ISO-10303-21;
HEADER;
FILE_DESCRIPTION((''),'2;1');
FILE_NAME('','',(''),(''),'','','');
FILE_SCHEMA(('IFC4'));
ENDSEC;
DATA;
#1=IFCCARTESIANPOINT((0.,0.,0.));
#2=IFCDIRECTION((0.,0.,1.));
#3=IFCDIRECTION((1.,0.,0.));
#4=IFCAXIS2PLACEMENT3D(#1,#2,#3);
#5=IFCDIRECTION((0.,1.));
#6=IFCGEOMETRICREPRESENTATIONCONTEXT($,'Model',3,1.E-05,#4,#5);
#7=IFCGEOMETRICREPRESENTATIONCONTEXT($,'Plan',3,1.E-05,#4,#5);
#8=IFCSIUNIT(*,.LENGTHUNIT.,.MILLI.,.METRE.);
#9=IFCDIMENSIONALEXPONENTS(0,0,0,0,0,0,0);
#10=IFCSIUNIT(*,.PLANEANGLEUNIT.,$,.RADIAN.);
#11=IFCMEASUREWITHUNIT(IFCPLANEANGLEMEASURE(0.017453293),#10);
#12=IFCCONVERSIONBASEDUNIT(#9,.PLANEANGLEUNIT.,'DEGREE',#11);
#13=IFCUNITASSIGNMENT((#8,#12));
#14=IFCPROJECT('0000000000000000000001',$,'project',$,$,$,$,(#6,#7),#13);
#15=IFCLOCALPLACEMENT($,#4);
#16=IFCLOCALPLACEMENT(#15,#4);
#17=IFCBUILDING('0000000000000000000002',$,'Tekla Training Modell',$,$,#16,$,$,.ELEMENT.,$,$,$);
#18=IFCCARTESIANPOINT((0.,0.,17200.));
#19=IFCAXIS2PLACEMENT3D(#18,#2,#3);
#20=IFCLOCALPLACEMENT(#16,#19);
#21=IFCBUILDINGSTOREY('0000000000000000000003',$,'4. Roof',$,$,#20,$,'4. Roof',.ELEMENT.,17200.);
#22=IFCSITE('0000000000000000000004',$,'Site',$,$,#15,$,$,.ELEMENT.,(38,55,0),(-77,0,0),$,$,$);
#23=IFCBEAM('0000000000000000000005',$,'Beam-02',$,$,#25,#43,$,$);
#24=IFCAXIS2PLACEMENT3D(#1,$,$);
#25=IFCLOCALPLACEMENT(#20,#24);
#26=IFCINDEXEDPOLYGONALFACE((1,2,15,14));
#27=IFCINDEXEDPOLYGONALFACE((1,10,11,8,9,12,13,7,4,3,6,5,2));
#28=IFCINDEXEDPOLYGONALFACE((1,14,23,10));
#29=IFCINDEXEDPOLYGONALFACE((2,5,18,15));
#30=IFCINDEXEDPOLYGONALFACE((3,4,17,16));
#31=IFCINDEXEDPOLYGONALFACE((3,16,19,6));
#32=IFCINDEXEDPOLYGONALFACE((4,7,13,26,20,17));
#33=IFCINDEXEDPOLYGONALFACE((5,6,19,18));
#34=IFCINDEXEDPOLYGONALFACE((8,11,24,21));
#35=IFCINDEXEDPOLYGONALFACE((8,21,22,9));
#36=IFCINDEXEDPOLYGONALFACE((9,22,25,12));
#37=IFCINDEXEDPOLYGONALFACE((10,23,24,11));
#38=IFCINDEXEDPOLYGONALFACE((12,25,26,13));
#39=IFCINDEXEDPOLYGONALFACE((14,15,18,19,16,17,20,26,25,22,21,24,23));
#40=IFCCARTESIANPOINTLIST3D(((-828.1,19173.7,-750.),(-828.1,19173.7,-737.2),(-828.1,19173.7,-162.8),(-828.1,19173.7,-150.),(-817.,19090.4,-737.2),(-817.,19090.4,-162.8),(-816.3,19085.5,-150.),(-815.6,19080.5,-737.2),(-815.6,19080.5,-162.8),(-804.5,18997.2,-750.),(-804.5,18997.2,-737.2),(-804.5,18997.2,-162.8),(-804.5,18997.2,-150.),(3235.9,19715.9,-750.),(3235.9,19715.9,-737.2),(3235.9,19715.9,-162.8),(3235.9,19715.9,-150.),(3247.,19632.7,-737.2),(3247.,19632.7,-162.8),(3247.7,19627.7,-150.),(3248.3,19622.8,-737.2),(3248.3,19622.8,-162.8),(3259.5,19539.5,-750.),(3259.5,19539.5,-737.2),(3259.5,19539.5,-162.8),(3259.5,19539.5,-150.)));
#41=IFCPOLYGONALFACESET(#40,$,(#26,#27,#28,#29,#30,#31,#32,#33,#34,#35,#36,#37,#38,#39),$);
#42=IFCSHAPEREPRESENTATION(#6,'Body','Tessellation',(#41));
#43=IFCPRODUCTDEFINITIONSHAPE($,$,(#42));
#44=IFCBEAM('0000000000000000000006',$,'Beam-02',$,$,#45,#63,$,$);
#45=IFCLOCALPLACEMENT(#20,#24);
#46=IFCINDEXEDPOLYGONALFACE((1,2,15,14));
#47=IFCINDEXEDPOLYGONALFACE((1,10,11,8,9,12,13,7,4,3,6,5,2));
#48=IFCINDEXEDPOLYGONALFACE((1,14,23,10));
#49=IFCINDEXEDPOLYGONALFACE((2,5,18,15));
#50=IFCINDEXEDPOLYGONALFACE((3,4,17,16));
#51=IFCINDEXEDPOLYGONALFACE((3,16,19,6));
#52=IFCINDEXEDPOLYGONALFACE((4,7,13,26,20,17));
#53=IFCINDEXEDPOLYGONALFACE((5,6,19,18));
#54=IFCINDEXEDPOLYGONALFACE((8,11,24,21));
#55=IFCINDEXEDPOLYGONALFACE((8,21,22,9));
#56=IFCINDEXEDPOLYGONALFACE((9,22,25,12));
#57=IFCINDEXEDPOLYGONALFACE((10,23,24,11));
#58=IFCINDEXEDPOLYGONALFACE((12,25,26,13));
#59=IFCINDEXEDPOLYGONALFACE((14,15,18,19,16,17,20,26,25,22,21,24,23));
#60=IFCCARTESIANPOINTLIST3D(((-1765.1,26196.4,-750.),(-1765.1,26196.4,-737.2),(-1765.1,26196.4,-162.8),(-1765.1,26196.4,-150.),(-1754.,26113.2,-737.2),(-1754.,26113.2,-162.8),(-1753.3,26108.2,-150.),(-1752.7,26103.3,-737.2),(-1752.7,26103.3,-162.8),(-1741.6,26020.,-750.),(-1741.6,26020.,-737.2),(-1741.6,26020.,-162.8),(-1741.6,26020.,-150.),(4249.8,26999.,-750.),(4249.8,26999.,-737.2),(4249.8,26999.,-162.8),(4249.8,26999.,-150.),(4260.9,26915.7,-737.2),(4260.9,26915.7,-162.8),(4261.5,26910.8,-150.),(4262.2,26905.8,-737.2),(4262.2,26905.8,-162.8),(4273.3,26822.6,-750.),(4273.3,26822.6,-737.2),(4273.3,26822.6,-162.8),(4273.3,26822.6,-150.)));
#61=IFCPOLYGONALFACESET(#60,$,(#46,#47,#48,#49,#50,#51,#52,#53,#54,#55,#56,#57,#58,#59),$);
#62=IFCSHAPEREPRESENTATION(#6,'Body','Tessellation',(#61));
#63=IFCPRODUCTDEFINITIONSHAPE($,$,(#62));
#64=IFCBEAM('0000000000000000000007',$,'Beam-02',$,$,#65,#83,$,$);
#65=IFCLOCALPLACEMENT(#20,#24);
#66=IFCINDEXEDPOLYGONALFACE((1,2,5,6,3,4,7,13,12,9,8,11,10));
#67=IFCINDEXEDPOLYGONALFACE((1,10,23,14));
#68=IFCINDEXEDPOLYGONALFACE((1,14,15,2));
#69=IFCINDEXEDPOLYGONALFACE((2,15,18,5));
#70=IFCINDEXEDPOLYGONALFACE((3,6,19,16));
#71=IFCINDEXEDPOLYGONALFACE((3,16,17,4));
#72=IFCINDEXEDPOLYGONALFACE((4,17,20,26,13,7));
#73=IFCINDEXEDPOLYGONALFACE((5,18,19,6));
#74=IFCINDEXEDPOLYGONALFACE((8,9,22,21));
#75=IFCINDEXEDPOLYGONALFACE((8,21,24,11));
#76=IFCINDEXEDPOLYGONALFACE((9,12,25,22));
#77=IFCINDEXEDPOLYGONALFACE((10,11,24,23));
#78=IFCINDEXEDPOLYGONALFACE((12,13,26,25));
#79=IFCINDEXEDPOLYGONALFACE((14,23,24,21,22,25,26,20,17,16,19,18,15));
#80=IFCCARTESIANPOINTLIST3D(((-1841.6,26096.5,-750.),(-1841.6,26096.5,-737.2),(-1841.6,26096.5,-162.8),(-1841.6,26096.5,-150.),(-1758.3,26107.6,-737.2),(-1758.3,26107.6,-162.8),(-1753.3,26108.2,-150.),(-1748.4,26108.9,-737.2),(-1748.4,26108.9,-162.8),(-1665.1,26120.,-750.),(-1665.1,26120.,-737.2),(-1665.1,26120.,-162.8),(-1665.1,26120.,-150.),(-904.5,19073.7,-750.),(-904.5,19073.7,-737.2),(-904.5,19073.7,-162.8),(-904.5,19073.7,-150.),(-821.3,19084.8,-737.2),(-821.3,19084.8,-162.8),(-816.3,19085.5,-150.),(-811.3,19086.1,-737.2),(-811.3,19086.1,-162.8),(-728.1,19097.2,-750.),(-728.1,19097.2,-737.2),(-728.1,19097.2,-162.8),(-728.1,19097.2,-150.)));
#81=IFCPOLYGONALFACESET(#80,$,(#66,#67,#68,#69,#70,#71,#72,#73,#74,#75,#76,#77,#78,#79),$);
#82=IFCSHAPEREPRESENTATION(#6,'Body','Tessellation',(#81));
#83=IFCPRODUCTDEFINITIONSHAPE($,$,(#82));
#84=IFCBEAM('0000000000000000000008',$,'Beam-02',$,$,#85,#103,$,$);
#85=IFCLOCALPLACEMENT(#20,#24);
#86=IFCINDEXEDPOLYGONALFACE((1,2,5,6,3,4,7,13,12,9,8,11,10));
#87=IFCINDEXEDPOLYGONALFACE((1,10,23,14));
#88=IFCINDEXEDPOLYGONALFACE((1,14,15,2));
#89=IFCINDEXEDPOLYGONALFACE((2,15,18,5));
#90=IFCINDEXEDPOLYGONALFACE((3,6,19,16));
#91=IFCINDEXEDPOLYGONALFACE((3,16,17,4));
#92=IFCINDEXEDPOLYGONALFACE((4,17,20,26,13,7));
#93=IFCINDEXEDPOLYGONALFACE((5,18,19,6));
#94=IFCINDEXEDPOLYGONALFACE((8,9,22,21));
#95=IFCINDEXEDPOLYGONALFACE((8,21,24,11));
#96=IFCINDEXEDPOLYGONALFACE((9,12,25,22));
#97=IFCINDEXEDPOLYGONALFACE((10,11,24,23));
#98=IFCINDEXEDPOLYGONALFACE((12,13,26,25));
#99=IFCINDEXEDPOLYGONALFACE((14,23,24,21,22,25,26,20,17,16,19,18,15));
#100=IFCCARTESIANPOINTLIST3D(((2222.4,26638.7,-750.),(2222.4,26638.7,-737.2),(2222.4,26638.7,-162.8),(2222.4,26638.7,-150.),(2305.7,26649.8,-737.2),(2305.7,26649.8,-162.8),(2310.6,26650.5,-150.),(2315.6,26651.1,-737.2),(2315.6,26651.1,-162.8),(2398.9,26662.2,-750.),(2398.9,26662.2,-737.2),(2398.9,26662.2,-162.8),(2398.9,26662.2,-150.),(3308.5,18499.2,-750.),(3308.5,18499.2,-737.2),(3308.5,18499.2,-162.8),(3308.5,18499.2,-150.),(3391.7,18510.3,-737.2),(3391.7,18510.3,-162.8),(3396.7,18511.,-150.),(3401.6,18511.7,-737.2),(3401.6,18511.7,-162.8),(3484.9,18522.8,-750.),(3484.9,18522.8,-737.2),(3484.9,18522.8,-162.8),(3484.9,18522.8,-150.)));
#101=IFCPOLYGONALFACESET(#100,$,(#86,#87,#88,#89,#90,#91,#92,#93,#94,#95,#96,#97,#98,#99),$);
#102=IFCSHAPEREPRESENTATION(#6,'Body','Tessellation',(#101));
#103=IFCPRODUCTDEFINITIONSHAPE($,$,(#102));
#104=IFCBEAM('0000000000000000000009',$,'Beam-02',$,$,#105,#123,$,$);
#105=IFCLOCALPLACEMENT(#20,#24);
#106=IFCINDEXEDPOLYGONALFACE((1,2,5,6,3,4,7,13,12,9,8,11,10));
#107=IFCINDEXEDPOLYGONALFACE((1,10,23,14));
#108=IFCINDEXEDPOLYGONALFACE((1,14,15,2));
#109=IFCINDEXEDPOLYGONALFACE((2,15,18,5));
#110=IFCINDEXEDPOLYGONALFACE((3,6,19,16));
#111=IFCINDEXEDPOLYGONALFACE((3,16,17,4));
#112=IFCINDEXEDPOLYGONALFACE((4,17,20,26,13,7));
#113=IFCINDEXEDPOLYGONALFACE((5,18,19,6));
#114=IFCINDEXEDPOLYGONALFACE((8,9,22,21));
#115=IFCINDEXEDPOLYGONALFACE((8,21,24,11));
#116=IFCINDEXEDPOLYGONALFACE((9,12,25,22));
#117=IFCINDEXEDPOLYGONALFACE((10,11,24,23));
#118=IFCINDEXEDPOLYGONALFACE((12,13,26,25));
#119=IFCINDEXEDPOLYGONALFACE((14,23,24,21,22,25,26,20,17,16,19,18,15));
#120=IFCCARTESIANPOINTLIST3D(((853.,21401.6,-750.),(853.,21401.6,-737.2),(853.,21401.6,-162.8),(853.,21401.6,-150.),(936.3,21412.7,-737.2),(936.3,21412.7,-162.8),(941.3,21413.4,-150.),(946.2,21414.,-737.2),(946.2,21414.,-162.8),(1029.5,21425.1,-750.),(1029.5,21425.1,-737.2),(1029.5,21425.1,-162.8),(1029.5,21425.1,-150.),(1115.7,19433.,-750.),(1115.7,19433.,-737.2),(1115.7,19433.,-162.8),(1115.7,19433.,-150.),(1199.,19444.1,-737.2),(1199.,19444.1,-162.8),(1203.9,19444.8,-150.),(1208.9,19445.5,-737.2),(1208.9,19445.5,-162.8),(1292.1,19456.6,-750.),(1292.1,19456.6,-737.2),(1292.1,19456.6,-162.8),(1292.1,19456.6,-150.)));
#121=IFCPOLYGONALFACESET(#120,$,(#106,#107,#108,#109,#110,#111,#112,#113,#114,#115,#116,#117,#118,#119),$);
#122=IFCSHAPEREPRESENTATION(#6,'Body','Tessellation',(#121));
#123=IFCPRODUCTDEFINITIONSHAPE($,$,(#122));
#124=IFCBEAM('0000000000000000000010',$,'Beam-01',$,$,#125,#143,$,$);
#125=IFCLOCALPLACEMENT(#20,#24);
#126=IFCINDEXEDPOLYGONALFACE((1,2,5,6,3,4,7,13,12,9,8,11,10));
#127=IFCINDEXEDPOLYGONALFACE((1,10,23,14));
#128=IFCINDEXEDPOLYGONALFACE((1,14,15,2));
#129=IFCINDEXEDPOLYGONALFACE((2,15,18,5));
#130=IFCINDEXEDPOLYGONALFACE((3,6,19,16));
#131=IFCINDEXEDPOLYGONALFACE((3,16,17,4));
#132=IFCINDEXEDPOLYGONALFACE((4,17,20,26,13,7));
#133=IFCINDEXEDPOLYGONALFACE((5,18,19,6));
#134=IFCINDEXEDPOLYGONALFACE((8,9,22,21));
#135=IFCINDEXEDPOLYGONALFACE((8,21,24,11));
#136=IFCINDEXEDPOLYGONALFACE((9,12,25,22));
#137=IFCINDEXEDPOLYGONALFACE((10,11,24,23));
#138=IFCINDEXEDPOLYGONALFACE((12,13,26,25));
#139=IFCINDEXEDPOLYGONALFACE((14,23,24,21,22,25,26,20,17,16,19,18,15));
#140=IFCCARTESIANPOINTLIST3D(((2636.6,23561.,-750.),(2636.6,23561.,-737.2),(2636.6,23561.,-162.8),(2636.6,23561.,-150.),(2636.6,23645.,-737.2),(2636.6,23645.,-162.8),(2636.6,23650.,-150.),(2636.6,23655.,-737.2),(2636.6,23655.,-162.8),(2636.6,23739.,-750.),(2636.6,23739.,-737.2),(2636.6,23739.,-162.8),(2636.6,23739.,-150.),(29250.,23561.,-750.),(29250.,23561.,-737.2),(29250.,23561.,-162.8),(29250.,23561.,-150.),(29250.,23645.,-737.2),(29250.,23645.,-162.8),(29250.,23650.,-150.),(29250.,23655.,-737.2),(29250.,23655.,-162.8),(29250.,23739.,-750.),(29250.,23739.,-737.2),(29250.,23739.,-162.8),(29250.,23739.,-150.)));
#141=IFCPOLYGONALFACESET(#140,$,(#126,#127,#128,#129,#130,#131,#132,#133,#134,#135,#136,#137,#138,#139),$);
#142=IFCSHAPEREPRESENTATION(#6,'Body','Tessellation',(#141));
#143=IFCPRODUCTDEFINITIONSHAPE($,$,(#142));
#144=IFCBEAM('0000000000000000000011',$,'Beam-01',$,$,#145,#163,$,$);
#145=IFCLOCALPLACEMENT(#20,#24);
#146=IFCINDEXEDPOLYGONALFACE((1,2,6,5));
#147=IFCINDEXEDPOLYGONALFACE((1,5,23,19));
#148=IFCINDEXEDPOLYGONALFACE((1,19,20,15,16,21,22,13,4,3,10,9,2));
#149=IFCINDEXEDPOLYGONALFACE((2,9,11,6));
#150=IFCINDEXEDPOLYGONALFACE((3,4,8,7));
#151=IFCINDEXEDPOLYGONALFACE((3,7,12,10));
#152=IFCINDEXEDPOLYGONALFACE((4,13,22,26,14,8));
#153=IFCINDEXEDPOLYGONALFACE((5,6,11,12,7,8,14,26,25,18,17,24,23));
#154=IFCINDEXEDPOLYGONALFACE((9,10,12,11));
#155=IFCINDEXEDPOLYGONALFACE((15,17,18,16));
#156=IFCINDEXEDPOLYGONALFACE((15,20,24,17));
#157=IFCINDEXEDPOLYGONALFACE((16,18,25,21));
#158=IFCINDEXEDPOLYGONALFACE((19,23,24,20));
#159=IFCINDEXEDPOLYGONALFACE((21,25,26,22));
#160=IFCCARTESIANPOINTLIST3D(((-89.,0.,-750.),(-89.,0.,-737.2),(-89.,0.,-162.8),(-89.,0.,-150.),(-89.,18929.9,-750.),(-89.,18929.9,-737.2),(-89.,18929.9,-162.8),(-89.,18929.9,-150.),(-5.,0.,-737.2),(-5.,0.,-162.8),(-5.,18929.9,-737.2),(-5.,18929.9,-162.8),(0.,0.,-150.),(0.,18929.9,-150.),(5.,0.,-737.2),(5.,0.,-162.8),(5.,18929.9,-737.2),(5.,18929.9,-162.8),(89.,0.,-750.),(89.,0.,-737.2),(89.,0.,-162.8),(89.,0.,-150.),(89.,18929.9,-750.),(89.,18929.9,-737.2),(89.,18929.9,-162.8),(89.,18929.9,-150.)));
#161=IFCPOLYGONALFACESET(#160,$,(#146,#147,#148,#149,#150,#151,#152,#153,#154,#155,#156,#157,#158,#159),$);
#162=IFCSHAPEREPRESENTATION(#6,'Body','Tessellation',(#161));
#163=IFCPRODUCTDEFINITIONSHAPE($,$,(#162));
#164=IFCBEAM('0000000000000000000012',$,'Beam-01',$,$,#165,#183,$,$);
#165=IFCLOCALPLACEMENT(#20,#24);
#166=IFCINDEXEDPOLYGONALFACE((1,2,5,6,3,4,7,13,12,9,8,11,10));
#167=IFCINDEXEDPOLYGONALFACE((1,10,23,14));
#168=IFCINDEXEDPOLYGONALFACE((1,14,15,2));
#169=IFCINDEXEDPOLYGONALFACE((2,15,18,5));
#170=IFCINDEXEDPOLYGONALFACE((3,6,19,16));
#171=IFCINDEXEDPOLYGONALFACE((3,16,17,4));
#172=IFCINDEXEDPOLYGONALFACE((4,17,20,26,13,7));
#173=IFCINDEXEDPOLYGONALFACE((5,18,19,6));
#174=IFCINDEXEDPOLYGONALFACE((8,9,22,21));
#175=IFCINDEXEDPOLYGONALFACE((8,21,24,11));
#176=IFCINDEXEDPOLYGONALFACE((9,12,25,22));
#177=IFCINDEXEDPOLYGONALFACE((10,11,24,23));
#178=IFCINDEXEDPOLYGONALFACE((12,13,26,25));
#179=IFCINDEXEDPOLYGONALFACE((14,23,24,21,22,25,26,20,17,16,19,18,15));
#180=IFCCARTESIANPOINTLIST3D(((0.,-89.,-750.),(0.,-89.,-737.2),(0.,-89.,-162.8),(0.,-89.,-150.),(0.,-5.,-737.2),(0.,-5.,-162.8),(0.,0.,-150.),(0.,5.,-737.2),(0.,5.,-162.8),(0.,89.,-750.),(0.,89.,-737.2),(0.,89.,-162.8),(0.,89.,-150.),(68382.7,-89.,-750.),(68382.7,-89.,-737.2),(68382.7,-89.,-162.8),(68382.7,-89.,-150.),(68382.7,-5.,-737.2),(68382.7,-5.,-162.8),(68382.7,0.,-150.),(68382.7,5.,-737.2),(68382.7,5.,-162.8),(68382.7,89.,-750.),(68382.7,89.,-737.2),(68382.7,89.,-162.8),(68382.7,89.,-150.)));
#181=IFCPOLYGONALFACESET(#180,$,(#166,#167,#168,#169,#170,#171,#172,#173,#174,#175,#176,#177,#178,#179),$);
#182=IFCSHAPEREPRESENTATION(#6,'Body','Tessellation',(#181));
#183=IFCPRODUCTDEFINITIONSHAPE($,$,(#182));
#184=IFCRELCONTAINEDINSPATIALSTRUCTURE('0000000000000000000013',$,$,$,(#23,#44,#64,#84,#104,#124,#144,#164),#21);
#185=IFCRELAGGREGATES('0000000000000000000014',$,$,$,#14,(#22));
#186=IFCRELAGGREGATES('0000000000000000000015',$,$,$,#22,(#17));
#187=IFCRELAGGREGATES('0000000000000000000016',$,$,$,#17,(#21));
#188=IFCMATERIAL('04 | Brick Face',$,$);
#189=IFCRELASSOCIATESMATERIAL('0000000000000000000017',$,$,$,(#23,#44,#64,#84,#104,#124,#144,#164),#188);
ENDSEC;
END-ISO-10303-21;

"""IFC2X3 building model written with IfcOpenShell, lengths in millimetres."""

from ifc_helpers import new_model, entity, si_unit, converted_unit, direction, frame, origin_with_axes, place, context, project, spatial, polyline, outline, extrude, material, element, save


model = new_model("IFC2X3")

# Units and contexts
model_context = context("Model", 3, precision=1e-05, world=origin_with_axes(), true_north=direction((0.0, 1.0)))
plan_context = context("Plan", 3, precision=1e-05, world=origin_with_axes(), true_north=direction((0.0, 1.0)))
ifc_project = project(units=[si_unit("LENGTHUNIT", "METRE", prefix="MILLI"), converted_unit("PLANEANGLEUNIT", "DEGREE", entity("IfcPlaneAngleMeasure", 0.017453293), si_unit("PLANEANGLEUNIT", "RADIAN"), dimensions=[0, 0, 0, 0, 0, 0, 0])], contexts=[model_context, plan_context])

# Site, building, storey
site_placement = place(None, origin_with_axes())
site = spatial("IfcSite", under=ifc_project, at=site_placement, Name="Site", CompositionType="ELEMENT", RefLatitude=(38, 55, 0), RefLongitude=(-77, 0, 0))
building_placement = place(site_placement, origin_with_axes())
building = spatial("IfcBuilding", under=site, at=building_placement, Name="Tekla Training Modell", CompositionType="ELEMENT")
storey_placement = place(building_placement, frame((0.0, 0.0, 17200.0), z_axis=(0.0, 0.0, 1.0), x_axis=(1.0, 0.0, 0.0)))
storey = spatial("IfcBuildingStorey", under=building, at=storey_placement, Name="4. Roof", LongName="4. Roof", CompositionType="ELEMENT", Elevation=17200.0)

# Shared definitions
ifc_material_1 = material(Name="04 | Brick Face")

# Beams
for number, where, z_axis, x_axis, name in (
    (1, (-816.3, 19085.5, -450.0), (0.0, 0.0, 1.0), (0.132256, -0.991216, 0.0), "Beam-02"),
):
    element("IfcBeam", number, at=place(storey_placement, frame(where, z_axis=z_axis, x_axis=x_axis)), inside=storey, material=ifc_material_1, Name=name, context=model_context, shape_type="SweptSolid", body=[
        extrude(outline(polyline([(0.0, 300.0), (-89.0, 300.0), (-89.0, 287.2), (-5.0, 287.2), (-5.0, -287.2), (-89.0, -287.2), (-89.0, -300.0), (89.0, -300.0), (89.0, -287.2), (5.0, -287.2), (5.0, 287.2), (89.0, 287.2), (89.0, 300.0), (0.0, 300.0)])), frame((0.0, 4100.0, 0.0), z_axis=(0.0, -1.0, 0.0), x_axis=(1.0, 0.0, 0.0)), (0.0, 0.0, 1.0), 4100.0),
    ])
beam_1_placement = place(storey_placement, frame((-1753.3, 26108.2, -450.0), z_axis=(0.0, 0.0, 1.0), x_axis=(0.132256, -0.991216, 0.0)))
element("IfcBeam", 2, at=beam_1_placement, inside=storey, material=ifc_material_1, Name="Beam-02", context=model_context, shape_type="SweptSolid", body=[
    extrude(outline(polyline([(0.0, 300.0), (-89.0, 300.0), (-89.0, 287.2), (-5.0, 287.2), (-5.0, -287.2), (-89.0, -287.2), (-89.0, -300.0), (89.0, -300.0), (89.0, -287.2), (5.0, -287.2), (5.0, 287.2), (89.0, 287.2), (89.0, 300.0), (0.0, 300.0)])), frame((0.0, 6068.2, 0.0), z_axis=(0.0, -1.0, 0.0), x_axis=(1.0, 0.0, 0.0)), (0.0, 0.0, 1.0), 6068.2),
])
beam_2_placement = place(storey_placement, frame((-1753.3, 26108.2, -450.0), z_axis=(0.0, 0.0, 1.0), x_axis=(-0.991216, -0.132256, 0.0)))
element("IfcBeam", 3, at=beam_2_placement, inside=storey, material=ifc_material_1, Name="Beam-02", context=model_context, shape_type="SweptSolid", body=[
    extrude(outline(polyline([(0.0, 300.0), (-89.0, 300.0), (-89.0, 287.2), (-5.0, 287.2), (-5.0, -287.2), (-89.0, -287.2), (-89.0, -300.0), (89.0, -300.0), (89.0, -287.2), (5.0, -287.2), (5.0, 287.2), (89.0, 287.2), (89.0, 300.0), (0.0, 300.0)])), frame((0.0, 7085.0, 0.0), z_axis=(0.0, -1.0, 0.0), x_axis=(1.0, 0.0, 0.0)), (0.0, 0.0, 1.0), 7085.0),
])
beam_3_placement = place(storey_placement, frame((2310.6, 26650.5, -450.0), z_axis=(0.0, 0.0, 1.0), x_axis=(-0.991216, -0.132256, 0.0)))
element("IfcBeam", 4, at=beam_3_placement, inside=storey, material=ifc_material_1, Name="Beam-02", context=model_context, shape_type="SweptSolid", body=[
    extrude(outline(polyline([(0.0, 300.0), (-89.0, 300.0), (-89.0, 287.2), (-5.0, 287.2), (-5.0, -287.2), (-89.0, -287.2), (-89.0, -300.0), (89.0, -300.0), (89.0, -287.2), (5.0, -287.2), (5.0, 287.2), (89.0, 287.2), (89.0, 300.0), (0.0, 300.0)])), frame((0.0, 8211.6, 0.0), z_axis=(0.0, -1.0, 0.0), x_axis=(1.0, 0.0, 0.0)), (0.0, 0.0, 1.0), 8211.6),
])
beam_4_placement = place(storey_placement, frame((941.3, 21413.4, -450.0), z_axis=(0.0, 0.0, 1.0), x_axis=(-0.991216, -0.132256, 0.0)))
element("IfcBeam", 5, at=beam_4_placement, inside=storey, material=ifc_material_1, Name="Beam-02", context=model_context, shape_type="SweptSolid", body=[
    extrude(outline(polyline([(0.0, 300.0), (-89.0, 300.0), (-89.0, 287.2), (-5.0, 287.2), (-5.0, -287.2), (-89.0, -287.2), (-89.0, -300.0), (89.0, -300.0), (89.0, -287.2), (5.0, -287.2), (5.0, 287.2), (89.0, 287.2), (89.0, 300.0), (0.0, 300.0)])), frame((0.0, 1986.0, 0.0), z_axis=(0.0, -1.0, 0.0), x_axis=(1.0, 0.0, 0.0)), (0.0, 0.0, 1.0), 1986.0),
])
beam_5_placement = place(storey_placement, frame((2636.6, 23650.0, -450.0), z_axis=(0.0, 0.0, 1.0), x_axis=(0.0, -1.0, 0.0)))
element("IfcBeam", 6, at=beam_5_placement, inside=storey, material=ifc_material_1, Name="Beam-01", context=model_context, shape_type="SweptSolid", body=[
    extrude(outline(polyline([(0.0, 300.0), (-89.0, 300.0), (-89.0, 287.2), (-5.0, 287.2), (-5.0, -287.2), (-89.0, -287.2), (-89.0, -300.0), (89.0, -300.0), (89.0, -287.2), (5.0, -287.2), (5.0, 287.2), (89.0, 287.2), (89.0, 300.0), (0.0, 300.0)])), frame((0.0, 26613.4, 0.0), z_axis=(0.0, -1.0, 0.0), x_axis=(1.0, 0.0, 0.0)), (0.0, 0.0, 1.0), 26613.4),
])
beam_6_placement = place(storey_placement, frame((0.0, 18929.9, -450.0), z_axis=(0.0, 0.0, 1.0), x_axis=(-1.0, 0.0, 0.0)))
element("IfcBeam", 7, at=beam_6_placement, inside=storey, material=ifc_material_1, Name="Beam-01", context=model_context, shape_type="SweptSolid", body=[
    extrude(outline(polyline([(0.0, 300.0), (-89.0, 300.0), (-89.0, 287.2), (-5.0, 287.2), (-5.0, -287.2), (-89.0, -287.2), (-89.0, -300.0), (89.0, -300.0), (89.0, -287.2), (5.0, -287.2), (5.0, 287.2), (89.0, 287.2), (89.0, 300.0), (0.0, 300.0)])), frame((0.0, 18929.9, 0.0), z_axis=(0.0, -1.0, 0.0), x_axis=(1.0, 0.0, 0.0)), (0.0, 0.0, 1.0), 18929.9),
])
beam_7_placement = place(storey_placement, frame((0.0, 0.0, -450.0), z_axis=(0.0, 0.0, 1.0), x_axis=(0.0, -1.0, 0.0)))
element("IfcBeam", 8, at=beam_7_placement, inside=storey, material=ifc_material_1, Name="Beam-01", context=model_context, shape_type="SweptSolid", body=[
    extrude(outline(polyline([(0.0, 300.0), (-89.0, 300.0), (-89.0, 287.2), (-5.0, 287.2), (-5.0, -287.2), (-89.0, -287.2), (-89.0, -300.0), (89.0, -300.0), (89.0, -287.2), (5.0, -287.2), (5.0, 287.2), (89.0, 287.2), (89.0, 300.0), (0.0, 300.0)])), frame((0.0, 68382.7, 0.0), z_axis=(0.0, -1.0, 0.0), x_axis=(1.0, 0.0, 0.0)), (0.0, 0.0, 1.0), 68382.7),
])

save(model, "model.ifc")
